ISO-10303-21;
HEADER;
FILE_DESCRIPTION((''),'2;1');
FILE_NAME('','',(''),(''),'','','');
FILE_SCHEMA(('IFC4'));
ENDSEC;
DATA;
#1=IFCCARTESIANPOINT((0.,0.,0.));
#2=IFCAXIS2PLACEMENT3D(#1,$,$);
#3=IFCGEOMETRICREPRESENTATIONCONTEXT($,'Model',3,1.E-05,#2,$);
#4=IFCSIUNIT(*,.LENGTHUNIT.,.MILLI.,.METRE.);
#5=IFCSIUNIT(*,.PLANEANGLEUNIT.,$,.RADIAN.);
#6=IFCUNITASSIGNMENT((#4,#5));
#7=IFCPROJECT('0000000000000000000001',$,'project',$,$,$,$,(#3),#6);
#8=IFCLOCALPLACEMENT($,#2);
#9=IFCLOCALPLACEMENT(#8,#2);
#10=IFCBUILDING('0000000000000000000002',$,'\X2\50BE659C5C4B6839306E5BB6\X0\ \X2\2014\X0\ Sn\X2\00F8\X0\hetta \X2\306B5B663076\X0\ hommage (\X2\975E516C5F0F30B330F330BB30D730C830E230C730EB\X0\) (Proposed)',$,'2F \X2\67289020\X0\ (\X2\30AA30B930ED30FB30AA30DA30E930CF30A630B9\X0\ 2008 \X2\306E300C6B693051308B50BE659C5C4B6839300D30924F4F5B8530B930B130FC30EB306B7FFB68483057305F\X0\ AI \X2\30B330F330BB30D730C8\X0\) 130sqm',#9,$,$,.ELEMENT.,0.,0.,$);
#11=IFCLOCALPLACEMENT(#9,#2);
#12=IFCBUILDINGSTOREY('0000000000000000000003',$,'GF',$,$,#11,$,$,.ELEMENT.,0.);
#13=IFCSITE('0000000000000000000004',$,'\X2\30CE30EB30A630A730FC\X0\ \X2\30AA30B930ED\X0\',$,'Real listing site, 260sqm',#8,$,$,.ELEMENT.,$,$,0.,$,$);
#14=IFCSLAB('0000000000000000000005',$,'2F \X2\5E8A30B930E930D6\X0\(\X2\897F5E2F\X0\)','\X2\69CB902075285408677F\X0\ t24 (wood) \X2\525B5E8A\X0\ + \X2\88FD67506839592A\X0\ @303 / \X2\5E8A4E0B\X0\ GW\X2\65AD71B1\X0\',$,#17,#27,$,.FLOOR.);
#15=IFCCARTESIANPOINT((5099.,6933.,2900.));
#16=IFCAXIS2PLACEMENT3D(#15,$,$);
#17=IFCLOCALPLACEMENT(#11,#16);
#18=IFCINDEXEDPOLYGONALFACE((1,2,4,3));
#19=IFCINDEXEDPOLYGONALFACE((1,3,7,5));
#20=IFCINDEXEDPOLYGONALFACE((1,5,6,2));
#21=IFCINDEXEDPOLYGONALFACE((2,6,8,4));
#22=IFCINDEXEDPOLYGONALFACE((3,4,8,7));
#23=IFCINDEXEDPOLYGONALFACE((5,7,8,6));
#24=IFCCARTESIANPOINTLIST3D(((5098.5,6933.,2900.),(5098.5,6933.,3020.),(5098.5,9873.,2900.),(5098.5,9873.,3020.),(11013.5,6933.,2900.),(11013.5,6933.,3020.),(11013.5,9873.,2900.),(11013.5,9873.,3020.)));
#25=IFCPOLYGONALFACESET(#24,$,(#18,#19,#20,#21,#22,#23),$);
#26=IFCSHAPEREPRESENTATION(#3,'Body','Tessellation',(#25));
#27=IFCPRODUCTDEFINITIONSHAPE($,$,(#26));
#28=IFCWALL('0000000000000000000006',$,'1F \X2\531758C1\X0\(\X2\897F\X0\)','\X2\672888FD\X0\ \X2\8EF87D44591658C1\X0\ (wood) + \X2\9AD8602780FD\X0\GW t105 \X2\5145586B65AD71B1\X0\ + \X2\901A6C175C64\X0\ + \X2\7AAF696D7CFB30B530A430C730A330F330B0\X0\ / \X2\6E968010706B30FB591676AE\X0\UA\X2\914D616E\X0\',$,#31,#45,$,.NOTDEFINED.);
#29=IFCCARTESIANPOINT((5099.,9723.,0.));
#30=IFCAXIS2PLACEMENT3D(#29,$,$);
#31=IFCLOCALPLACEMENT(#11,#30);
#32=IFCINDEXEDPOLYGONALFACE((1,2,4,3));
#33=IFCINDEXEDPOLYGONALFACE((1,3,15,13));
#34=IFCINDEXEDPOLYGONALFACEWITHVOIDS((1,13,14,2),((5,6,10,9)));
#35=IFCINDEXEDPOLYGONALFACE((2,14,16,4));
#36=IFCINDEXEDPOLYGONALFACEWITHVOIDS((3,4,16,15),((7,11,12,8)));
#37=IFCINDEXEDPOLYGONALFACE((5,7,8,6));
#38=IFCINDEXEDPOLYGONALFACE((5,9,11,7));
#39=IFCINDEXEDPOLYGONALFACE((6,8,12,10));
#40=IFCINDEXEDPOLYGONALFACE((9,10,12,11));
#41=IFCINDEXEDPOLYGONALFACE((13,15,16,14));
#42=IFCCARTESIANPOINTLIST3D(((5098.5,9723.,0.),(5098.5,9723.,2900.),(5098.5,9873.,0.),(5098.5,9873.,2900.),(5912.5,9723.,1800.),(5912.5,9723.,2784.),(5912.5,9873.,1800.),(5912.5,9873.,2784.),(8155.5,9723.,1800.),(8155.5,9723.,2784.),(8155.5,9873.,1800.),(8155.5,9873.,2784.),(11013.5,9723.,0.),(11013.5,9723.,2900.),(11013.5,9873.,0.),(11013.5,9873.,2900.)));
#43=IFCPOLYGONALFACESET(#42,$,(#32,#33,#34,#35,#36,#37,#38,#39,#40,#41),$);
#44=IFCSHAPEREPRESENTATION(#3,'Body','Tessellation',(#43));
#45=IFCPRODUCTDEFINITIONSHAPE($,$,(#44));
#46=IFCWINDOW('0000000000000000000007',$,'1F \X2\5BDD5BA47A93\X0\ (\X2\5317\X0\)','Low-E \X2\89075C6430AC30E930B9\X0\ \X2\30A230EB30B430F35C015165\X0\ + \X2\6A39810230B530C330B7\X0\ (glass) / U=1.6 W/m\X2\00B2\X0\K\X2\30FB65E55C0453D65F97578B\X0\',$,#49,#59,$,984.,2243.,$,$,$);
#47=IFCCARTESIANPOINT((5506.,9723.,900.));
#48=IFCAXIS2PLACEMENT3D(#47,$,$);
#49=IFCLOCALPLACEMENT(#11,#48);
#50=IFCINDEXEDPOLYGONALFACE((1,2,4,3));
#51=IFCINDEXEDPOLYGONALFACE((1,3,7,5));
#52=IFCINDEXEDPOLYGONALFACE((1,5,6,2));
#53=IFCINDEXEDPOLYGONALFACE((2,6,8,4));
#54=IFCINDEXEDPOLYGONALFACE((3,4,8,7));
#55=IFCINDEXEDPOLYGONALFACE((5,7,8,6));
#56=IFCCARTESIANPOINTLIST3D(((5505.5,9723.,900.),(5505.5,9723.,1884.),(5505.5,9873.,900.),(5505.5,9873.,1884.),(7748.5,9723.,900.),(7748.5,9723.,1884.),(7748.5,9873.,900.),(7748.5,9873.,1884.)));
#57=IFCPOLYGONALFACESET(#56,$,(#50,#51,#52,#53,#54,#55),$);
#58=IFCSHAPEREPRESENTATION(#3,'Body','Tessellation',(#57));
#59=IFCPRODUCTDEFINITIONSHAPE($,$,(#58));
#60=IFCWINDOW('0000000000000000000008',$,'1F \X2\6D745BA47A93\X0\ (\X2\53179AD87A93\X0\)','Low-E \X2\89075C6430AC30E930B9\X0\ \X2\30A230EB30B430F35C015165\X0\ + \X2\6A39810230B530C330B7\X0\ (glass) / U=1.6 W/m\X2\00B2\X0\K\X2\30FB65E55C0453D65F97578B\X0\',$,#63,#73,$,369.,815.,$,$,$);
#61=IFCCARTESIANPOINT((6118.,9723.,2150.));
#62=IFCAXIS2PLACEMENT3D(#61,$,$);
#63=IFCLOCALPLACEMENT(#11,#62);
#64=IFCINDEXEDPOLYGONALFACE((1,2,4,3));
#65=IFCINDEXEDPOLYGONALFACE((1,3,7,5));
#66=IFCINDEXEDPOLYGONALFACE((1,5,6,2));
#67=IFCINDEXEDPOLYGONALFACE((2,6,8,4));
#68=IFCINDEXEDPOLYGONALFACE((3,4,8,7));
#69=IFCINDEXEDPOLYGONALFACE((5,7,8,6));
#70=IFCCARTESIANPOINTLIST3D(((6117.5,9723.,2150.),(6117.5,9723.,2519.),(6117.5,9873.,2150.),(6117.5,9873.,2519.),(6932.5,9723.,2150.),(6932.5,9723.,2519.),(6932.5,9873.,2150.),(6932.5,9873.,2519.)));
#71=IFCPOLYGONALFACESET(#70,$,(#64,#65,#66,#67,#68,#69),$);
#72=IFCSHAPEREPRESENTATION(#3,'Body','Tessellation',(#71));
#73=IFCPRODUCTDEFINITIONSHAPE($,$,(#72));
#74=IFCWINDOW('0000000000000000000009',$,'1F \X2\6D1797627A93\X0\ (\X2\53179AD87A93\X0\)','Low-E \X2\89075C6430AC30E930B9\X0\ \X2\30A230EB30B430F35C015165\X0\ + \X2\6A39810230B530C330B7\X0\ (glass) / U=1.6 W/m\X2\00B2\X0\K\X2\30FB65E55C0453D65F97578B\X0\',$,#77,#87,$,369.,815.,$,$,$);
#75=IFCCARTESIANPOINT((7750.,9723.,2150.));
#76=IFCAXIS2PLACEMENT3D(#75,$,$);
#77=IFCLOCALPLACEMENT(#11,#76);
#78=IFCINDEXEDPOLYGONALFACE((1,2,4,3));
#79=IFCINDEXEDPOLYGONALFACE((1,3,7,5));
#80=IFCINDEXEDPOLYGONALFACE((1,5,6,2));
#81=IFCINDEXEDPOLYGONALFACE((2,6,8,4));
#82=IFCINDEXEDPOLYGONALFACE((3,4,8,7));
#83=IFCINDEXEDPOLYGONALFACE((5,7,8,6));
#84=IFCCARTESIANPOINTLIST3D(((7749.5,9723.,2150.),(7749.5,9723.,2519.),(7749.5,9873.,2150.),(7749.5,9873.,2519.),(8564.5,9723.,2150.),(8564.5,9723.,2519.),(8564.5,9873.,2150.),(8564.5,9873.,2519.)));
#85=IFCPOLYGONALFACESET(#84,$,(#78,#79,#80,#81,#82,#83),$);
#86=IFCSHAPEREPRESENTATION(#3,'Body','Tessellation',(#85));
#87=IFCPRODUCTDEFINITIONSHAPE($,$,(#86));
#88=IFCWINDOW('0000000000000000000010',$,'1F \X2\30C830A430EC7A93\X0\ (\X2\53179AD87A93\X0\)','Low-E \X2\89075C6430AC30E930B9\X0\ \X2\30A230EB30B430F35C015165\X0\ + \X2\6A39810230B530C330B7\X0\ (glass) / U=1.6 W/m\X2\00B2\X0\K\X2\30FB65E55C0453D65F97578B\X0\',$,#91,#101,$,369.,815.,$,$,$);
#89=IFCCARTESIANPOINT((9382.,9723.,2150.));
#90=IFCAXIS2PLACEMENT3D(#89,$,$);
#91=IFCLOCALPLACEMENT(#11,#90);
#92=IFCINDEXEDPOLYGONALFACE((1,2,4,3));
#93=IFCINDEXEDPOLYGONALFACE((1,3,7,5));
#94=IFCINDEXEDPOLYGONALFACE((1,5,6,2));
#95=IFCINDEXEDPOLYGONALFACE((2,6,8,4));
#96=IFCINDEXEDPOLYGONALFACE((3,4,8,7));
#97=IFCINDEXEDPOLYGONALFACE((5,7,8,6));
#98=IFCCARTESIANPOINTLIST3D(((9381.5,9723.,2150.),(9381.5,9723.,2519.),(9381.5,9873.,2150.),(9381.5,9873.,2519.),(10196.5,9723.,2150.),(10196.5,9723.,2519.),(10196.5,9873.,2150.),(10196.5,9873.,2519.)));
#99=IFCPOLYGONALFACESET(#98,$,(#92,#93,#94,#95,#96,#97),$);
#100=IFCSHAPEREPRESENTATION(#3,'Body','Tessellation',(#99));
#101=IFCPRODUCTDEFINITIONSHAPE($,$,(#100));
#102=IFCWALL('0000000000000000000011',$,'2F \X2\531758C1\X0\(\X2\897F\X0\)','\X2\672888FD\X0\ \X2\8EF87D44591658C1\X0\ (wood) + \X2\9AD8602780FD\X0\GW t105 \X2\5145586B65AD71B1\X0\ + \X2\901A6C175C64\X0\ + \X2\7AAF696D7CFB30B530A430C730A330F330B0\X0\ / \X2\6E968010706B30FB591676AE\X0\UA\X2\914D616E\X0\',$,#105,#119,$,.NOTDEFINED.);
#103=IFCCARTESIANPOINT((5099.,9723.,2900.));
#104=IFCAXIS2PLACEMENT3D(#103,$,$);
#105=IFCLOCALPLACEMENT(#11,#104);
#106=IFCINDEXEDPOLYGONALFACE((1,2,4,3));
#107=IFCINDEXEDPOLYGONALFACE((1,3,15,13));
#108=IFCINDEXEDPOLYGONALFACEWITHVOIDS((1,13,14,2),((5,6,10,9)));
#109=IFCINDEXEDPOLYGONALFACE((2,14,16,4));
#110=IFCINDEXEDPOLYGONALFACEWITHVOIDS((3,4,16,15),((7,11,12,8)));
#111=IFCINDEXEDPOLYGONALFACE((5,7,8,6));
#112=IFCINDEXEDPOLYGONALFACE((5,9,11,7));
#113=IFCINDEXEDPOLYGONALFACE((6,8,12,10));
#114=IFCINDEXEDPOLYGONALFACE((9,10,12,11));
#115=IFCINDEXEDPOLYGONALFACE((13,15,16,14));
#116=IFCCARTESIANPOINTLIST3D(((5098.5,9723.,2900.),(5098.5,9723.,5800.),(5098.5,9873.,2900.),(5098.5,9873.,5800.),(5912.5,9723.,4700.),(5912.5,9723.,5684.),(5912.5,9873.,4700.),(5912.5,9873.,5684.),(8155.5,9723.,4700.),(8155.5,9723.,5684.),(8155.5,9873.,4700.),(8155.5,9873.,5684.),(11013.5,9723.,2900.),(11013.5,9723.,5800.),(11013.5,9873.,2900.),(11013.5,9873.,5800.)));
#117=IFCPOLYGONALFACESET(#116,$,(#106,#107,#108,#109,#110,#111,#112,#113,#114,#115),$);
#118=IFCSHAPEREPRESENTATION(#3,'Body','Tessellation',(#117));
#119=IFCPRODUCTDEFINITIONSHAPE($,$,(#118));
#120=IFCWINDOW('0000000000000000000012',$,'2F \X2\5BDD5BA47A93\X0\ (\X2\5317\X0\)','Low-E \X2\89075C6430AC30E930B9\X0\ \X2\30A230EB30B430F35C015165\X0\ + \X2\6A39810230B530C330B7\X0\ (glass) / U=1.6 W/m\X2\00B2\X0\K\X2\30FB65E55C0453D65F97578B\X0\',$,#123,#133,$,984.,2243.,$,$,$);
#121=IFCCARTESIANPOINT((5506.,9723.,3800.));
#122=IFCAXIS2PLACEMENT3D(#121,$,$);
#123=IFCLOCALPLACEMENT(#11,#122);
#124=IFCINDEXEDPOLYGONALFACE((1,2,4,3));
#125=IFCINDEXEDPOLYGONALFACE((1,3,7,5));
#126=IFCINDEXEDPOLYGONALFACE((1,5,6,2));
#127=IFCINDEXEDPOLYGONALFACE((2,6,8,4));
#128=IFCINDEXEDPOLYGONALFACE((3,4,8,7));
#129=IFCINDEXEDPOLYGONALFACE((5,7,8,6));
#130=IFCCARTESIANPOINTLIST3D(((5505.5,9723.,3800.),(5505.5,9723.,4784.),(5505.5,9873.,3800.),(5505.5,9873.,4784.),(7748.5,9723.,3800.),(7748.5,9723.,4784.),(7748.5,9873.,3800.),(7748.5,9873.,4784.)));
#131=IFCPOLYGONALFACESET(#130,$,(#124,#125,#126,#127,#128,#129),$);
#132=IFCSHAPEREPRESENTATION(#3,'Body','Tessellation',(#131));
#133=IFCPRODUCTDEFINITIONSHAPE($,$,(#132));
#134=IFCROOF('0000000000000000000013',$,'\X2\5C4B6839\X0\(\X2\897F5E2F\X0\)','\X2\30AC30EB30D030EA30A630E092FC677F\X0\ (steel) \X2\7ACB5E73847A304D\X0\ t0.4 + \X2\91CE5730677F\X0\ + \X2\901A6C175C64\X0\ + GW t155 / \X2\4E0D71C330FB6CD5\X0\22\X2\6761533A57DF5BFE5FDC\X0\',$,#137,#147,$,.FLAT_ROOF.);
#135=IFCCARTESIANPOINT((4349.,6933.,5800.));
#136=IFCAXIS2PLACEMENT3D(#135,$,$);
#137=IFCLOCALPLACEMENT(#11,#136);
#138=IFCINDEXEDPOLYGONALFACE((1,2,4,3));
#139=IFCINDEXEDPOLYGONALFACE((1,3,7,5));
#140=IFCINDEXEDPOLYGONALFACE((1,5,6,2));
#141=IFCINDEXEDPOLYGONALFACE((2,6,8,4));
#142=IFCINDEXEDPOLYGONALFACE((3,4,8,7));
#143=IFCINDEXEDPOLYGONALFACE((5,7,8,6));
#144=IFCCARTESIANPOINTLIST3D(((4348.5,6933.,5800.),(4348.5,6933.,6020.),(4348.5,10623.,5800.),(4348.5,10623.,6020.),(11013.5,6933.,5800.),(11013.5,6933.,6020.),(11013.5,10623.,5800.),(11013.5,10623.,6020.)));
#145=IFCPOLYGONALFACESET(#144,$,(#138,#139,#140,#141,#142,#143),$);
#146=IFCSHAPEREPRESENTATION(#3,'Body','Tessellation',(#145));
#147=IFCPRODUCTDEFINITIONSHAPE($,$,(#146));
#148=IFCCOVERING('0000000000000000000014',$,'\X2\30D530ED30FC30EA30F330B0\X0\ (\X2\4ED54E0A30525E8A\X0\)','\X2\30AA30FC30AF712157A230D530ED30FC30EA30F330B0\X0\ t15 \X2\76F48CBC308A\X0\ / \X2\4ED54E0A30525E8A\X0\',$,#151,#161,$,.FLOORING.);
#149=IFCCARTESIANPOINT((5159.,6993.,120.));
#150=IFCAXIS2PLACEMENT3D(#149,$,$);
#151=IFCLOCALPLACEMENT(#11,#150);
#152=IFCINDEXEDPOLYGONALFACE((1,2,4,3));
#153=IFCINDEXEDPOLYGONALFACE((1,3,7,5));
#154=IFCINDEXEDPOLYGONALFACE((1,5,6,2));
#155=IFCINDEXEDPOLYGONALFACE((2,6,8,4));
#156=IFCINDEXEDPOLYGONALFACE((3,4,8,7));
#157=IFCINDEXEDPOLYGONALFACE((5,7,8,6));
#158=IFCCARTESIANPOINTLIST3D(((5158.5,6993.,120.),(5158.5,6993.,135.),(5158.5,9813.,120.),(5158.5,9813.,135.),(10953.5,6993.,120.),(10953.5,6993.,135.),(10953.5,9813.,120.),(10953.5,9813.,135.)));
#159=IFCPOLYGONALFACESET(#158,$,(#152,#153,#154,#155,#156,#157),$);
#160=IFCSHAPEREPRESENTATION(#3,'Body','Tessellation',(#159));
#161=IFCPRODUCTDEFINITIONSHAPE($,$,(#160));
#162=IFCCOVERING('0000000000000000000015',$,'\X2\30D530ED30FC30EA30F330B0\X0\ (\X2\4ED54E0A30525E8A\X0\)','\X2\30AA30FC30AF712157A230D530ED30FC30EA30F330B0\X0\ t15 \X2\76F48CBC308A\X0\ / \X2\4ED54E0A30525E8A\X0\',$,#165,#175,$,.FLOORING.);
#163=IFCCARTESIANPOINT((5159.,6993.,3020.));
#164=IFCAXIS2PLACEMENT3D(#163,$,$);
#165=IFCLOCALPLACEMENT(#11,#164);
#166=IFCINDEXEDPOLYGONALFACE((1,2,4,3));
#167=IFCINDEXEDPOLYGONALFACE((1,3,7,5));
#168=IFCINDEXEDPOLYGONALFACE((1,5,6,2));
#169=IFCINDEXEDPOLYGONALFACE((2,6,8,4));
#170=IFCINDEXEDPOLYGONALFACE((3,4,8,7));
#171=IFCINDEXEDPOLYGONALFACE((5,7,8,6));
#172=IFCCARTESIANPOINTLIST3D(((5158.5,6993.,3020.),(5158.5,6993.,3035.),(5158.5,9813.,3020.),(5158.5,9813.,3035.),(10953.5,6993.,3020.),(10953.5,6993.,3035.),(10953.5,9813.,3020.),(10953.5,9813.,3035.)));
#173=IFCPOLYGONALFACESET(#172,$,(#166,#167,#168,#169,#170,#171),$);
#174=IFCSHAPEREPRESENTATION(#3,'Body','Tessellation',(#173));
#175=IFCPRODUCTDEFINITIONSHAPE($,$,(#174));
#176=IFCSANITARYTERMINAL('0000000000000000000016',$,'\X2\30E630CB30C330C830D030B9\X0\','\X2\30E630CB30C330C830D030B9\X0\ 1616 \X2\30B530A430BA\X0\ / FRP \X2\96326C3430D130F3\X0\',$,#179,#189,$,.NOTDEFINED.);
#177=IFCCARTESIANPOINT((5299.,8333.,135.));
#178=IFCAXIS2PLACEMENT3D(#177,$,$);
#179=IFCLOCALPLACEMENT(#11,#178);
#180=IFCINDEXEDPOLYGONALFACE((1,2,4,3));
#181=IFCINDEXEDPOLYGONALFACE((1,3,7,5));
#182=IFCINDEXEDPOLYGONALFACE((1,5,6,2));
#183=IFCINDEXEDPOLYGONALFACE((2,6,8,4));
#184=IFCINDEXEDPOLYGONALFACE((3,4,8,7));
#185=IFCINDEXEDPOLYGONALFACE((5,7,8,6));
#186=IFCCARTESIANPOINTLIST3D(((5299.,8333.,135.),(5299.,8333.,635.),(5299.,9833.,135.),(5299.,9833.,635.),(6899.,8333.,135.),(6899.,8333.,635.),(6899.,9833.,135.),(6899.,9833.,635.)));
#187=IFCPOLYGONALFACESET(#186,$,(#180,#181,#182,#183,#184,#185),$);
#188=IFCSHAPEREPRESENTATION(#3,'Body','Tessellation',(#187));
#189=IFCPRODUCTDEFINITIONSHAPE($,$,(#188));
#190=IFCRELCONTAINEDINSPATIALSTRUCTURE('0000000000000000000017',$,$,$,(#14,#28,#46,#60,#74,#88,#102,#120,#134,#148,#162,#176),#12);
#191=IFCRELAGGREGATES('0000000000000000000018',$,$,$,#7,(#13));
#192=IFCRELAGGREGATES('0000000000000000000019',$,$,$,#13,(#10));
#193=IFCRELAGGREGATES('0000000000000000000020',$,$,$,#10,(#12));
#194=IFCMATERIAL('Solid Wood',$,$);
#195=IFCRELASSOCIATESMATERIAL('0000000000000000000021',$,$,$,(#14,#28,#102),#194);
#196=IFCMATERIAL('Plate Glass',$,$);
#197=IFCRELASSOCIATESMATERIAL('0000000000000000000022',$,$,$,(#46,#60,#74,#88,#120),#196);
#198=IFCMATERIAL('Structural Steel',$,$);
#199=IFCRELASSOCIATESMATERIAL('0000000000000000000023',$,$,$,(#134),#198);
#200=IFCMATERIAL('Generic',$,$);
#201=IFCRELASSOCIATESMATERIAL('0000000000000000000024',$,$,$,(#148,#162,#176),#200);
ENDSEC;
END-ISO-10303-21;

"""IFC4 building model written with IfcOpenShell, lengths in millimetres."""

from ifc_helpers import new_model, si_unit, frame, frame_2d, origin, place, context, project, spatial, rectangle, extrude, material, element, fill, save


model = new_model("IFC4")

# Units and contexts
model_context = context("Model", 3, precision=1e-05, world=origin())
ifc_project = project(units=[si_unit("LENGTHUNIT", "METRE", prefix="MILLI"), si_unit("PLANEANGLEUNIT", "RADIAN")], contexts=[model_context])

# Site, building, storey
site_placement = place(None, origin())
site = spatial("IfcSite", under=ifc_project, at=site_placement, Name="ノルウェー オスロ", ObjectType="Real listing site, 260sqm", CompositionType="ELEMENT", RefElevation=0.0)
building_placement = place(site_placement, origin())
building = spatial("IfcBuilding", under=site, at=building_placement, Name="傾斜屋根の家 — Snøhetta に学ぶ hommage (非公式コンセプトモデル) (Proposed)", ObjectType="2F 木造 (オスロ・オペラハウス 2008 の「歩ける傾斜屋根」を住宅スケールに翻案した AI コンセプト) 130sqm", CompositionType="ELEMENT", ElevationOfRefHeight=0.0, ElevationOfTerrain=0.0)
storey_placement = place(building_placement, origin())
storey = spatial("IfcBuildingStorey", under=building, at=storey_placement, Name="GF", CompositionType="ELEMENT", Elevation=0.0)

# Slab
ifc_material_1 = material(Name="Solid Wood")
slab_1_placement = place(storey_placement, frame((5099.0, 6933.0, 2900.0)))
element("IfcSlab", 1, at=slab_1_placement, inside=storey, material=ifc_material_1, Name="2F 床スラブ(西帯)", Description="構造用合板 t24 (wood) 剛床 + 製材根太 @303 / 床下 GW断熱", PredefinedType="FLOOR", context=model_context, shape_type="SweptSolid", body=[
    extrude(rectangle(XDim=5915.0, YDim=2940.0, at=frame_2d((2957.0, 1470.0))), frame((5099.0, 6933.0, 2900.0)), (0.0, 0.0, 1.0), 120.0),
])

# Wall, openings, windows
wall_1_placement = place(storey_placement, frame((5099.0, 9723.0, 0.0)))
wall_1 = element("IfcWall", 2, at=wall_1_placement, inside=storey, material=ifc_material_1, Name="1F 北壁(西)", Description="木製 軸組外壁 (wood) + 高性能GW t105 充填断熱 + 通気層 + 窯業系サイディング / 準耐火・外皮UA配慮", PredefinedType="NOTDEFINED", context=model_context, shape_type="SweptSolid", body=[
    extrude(rectangle(XDim=5915.0, YDim=150.0, at=frame_2d((2957.0, 75.0))), frame((5099.0, 9723.0, 0.0)), (0.0, 0.0, 1.0), 2900.0),
])
opening_1_placement = place(storey_placement, frame((5506.0, 9723.0, 900.0)))
opening_1 = element("IfcOpeningElement", 3, at=opening_1_placement, cuts=wall_1, PredefinedType="NOTDEFINED", context=model_context, shape_type="SweptSolid", body=[
    extrude(rectangle(XDim=2243.0, YDim=150.0, at=frame_2d((1121.0, 75.0))), frame((5506.0, 9723.0, 900.0)), (0.0, 0.0, 1.0), 984.0),
])
opening_2_placement = place(storey_placement, frame((6118.0, 9723.0, 2150.0)))
opening_2 = element("IfcOpeningElement", 4, at=opening_2_placement, cuts=wall_1, PredefinedType="NOTDEFINED", context=model_context, shape_type="SweptSolid", body=[
    extrude(rectangle(XDim=815.0, YDim=150.0, at=frame_2d((407.0, 75.0))), frame((6118.0, 9723.0, 2150.0)), (0.0, 0.0, 1.0), 369.0),
])
opening_3_placement = place(storey_placement, frame((7750.0, 9723.0, 2150.0)))
opening_3 = element("IfcOpeningElement", 5, at=opening_3_placement, cuts=wall_1, PredefinedType="NOTDEFINED", context=model_context, shape_type="SweptSolid", body=[
    extrude(rectangle(XDim=815.0, YDim=150.0, at=frame_2d((407.0, 75.0))), frame((7750.0, 9723.0, 2150.0)), (0.0, 0.0, 1.0), 369.0),
])
opening_4_placement = place(storey_placement, frame((9382.0, 9723.0, 2150.0)))
opening_4 = element("IfcOpeningElement", 6, at=opening_4_placement, cuts=wall_1, PredefinedType="NOTDEFINED", context=model_context, shape_type="SweptSolid", body=[
    extrude(rectangle(XDim=815.0, YDim=150.0, at=frame_2d((407.0, 75.0))), frame((9382.0, 9723.0, 2150.0)), (0.0, 0.0, 1.0), 369.0),
])
ifc_material_2 = material(Name="Plate Glass")
window_1_placement = place(storey_placement, frame((5506.0, 9723.0, 900.0)))
window_1 = element("IfcWindow", 7, at=window_1_placement, inside=storey, material=ifc_material_2, Name="1F 寝室窓 (北)", Description="Low-E 複層ガラス アルゴン封入 + 樹脂サッシ (glass) / U=1.6 W/m²K・日射取得型", OverallHeight=984.0, OverallWidth=2243.0, context=model_context, shape_type="SweptSolid", body=[
    extrude(rectangle(XDim=2243.0, YDim=150.0, at=frame_2d((1121.0, 75.0))), frame((5506.0, 9723.0, 900.0)), (0.0, 0.0, 1.0), 984.0),
])
fill(opening_1, window_1)
window_2_placement = place(storey_placement, frame((6118.0, 9723.0, 2150.0)))
window_2 = element("IfcWindow", 8, at=window_2_placement, inside=storey, material=ifc_material_2, Name="1F 浴室窓 (北高窓)", Description="Low-E 複層ガラス アルゴン封入 + 樹脂サッシ (glass) / U=1.6 W/m²K・日射取得型", OverallHeight=369.0, OverallWidth=815.0, context=model_context, shape_type="SweptSolid", body=[
    extrude(rectangle(XDim=815.0, YDim=150.0, at=frame_2d((407.0, 75.0))), frame((6118.0, 9723.0, 2150.0)), (0.0, 0.0, 1.0), 369.0),
])
fill(opening_2, window_2)
window_3_placement = place(storey_placement, frame((7750.0, 9723.0, 2150.0)))
window_3 = element("IfcWindow", 9, at=window_3_placement, inside=storey, material=ifc_material_2, Name="1F 洗面窓 (北高窓)", Description="Low-E 複層ガラス アルゴン封入 + 樹脂サッシ (glass) / U=1.6 W/m²K・日射取得型", OverallHeight=369.0, OverallWidth=815.0, context=model_context, shape_type="SweptSolid", body=[
    extrude(rectangle(XDim=815.0, YDim=150.0, at=frame_2d((407.0, 75.0))), frame((7750.0, 9723.0, 2150.0)), (0.0, 0.0, 1.0), 369.0),
])
fill(opening_3, window_3)
window_4_placement = place(storey_placement, frame((9382.0, 9723.0, 2150.0)))
window_4 = element("IfcWindow", 10, at=window_4_placement, inside=storey, material=ifc_material_2, Name="1F トイレ窓 (北高窓)", Description="Low-E 複層ガラス アルゴン封入 + 樹脂サッシ (glass) / U=1.6 W/m²K・日射取得型", OverallHeight=369.0, OverallWidth=815.0, context=model_context, shape_type="SweptSolid", body=[
    extrude(rectangle(XDim=815.0, YDim=150.0, at=frame_2d((407.0, 75.0))), frame((9382.0, 9723.0, 2150.0)), (0.0, 0.0, 1.0), 369.0),
])
fill(opening_4, window_4)

# Wall, opening, window
wall_2_placement = place(storey_placement, frame((5099.0, 9723.0, 2900.0)))
wall_2 = element("IfcWall", 11, at=wall_2_placement, inside=storey, material=ifc_material_1, Name="2F 北壁(西)", Description="木製 軸組外壁 (wood) + 高性能GW t105 充填断熱 + 通気層 + 窯業系サイディング / 準耐火・外皮UA配慮", PredefinedType="NOTDEFINED", context=model_context, shape_type="SweptSolid", body=[
    extrude(rectangle(XDim=5915.0, YDim=150.0, at=frame_2d((2957.0, 75.0))), frame((5099.0, 9723.0, 2900.0)), (0.0, 0.0, 1.0), 2900.0),
])
opening_5_placement = place(storey_placement, frame((5506.0, 9723.0, 3800.0)))
opening_5 = element("IfcOpeningElement", 12, at=opening_5_placement, cuts=wall_2, PredefinedType="NOTDEFINED", context=model_context, shape_type="SweptSolid", body=[
    extrude(rectangle(XDim=2243.0, YDim=150.0, at=frame_2d((1121.0, 75.0))), frame((5506.0, 9723.0, 3800.0)), (0.0, 0.0, 1.0), 984.0),
])
window_5_placement = place(storey_placement, frame((5506.0, 9723.0, 3800.0)))
window_5 = element("IfcWindow", 13, at=window_5_placement, inside=storey, material=ifc_material_2, Name="2F 寝室窓 (北)", Description="Low-E 複層ガラス アルゴン封入 + 樹脂サッシ (glass) / U=1.6 W/m²K・日射取得型", OverallHeight=984.0, OverallWidth=2243.0, context=model_context, shape_type="SweptSolid", body=[
    extrude(rectangle(XDim=2243.0, YDim=150.0, at=frame_2d((1121.0, 75.0))), frame((5506.0, 9723.0, 3800.0)), (0.0, 0.0, 1.0), 984.0),
])
fill(opening_5, window_5)

# Roof
ifc_material_3 = material(Name="Structural Steel")
for number, where, name in (
    (14, (4349.0, 6933.0, 5800.0), "屋根(西帯)"),
):
    element("IfcRoof", number, at=place(storey_placement, frame(where)), inside=storey, material=ifc_material_3, Name=name, Description="ガルバリウム鋼板 (steel) 立平葺き t0.4 + 野地板 + 通気層 + GW t155 / 不燃・法22条区域対応", PredefinedType="FLAT_ROOF", context=model_context, shape_type="SweptSolid", body=[
        extrude(rectangle(XDim=6665.0, YDim=3690.0, at=frame_2d((3332.0, 1845.0))), frame((4349.0, 6933.0, 5800.0)), (0.0, 0.0, 1.0), 220.0),
    ])

# Coverings
ifc_material_4 = material(Name="Generic")
covering_1_placement = place(storey_placement, frame((5159.0, 6993.0, 120.0)))
element("IfcCovering", 15, at=covering_1_placement, inside=storey, material=ifc_material_4, Name="フローリング (仕上げ床)", Description="オーク無垢フローリング t15 直貼り / 仕上げ床", PredefinedType="FLOORING", context=model_context, shape_type="SweptSolid", body=[
    extrude(rectangle(XDim=5795.0, YDim=2820.0, at=frame_2d((2897.0, 1410.0))), frame((5159.0, 6993.0, 120.0)), (0.0, 0.0, 1.0), 15.0),
])
covering_2_placement = place(storey_placement, frame((5159.0, 6993.0, 3020.0)))
element("IfcCovering", 16, at=covering_2_placement, inside=storey, material=ifc_material_4, Name="フローリング (仕上げ床)", Description="オーク無垢フローリング t15 直貼り / 仕上げ床", PredefinedType="FLOORING", context=model_context, shape_type="SweptSolid", body=[
    extrude(rectangle(XDim=5795.0, YDim=2820.0, at=frame_2d((2897.0, 1410.0))), frame((5159.0, 6993.0, 3020.0)), (0.0, 0.0, 1.0), 15.0),
])

# Sanitary terminal
sanitary_terminal_placement = place(storey_placement, frame((5299.0, 8333.0, 135.0)))
element("IfcSanitaryTerminal", 17, at=sanitary_terminal_placement, inside=storey, material=ifc_material_4, Name="ユニットバス", Description="ユニットバス 1616 サイズ / FRP 防水パン", PredefinedType="NOTDEFINED", context=model_context, shape_type="SweptSolid", body=[
    extrude(rectangle(XDim=1600.0, YDim=1500.0, at=frame_2d((800.0, 750.0))), frame((5299.0, 8333.0, 135.0)), (0.0, 0.0, 1.0), 500.0),
])

save(model, "model.ifc")
